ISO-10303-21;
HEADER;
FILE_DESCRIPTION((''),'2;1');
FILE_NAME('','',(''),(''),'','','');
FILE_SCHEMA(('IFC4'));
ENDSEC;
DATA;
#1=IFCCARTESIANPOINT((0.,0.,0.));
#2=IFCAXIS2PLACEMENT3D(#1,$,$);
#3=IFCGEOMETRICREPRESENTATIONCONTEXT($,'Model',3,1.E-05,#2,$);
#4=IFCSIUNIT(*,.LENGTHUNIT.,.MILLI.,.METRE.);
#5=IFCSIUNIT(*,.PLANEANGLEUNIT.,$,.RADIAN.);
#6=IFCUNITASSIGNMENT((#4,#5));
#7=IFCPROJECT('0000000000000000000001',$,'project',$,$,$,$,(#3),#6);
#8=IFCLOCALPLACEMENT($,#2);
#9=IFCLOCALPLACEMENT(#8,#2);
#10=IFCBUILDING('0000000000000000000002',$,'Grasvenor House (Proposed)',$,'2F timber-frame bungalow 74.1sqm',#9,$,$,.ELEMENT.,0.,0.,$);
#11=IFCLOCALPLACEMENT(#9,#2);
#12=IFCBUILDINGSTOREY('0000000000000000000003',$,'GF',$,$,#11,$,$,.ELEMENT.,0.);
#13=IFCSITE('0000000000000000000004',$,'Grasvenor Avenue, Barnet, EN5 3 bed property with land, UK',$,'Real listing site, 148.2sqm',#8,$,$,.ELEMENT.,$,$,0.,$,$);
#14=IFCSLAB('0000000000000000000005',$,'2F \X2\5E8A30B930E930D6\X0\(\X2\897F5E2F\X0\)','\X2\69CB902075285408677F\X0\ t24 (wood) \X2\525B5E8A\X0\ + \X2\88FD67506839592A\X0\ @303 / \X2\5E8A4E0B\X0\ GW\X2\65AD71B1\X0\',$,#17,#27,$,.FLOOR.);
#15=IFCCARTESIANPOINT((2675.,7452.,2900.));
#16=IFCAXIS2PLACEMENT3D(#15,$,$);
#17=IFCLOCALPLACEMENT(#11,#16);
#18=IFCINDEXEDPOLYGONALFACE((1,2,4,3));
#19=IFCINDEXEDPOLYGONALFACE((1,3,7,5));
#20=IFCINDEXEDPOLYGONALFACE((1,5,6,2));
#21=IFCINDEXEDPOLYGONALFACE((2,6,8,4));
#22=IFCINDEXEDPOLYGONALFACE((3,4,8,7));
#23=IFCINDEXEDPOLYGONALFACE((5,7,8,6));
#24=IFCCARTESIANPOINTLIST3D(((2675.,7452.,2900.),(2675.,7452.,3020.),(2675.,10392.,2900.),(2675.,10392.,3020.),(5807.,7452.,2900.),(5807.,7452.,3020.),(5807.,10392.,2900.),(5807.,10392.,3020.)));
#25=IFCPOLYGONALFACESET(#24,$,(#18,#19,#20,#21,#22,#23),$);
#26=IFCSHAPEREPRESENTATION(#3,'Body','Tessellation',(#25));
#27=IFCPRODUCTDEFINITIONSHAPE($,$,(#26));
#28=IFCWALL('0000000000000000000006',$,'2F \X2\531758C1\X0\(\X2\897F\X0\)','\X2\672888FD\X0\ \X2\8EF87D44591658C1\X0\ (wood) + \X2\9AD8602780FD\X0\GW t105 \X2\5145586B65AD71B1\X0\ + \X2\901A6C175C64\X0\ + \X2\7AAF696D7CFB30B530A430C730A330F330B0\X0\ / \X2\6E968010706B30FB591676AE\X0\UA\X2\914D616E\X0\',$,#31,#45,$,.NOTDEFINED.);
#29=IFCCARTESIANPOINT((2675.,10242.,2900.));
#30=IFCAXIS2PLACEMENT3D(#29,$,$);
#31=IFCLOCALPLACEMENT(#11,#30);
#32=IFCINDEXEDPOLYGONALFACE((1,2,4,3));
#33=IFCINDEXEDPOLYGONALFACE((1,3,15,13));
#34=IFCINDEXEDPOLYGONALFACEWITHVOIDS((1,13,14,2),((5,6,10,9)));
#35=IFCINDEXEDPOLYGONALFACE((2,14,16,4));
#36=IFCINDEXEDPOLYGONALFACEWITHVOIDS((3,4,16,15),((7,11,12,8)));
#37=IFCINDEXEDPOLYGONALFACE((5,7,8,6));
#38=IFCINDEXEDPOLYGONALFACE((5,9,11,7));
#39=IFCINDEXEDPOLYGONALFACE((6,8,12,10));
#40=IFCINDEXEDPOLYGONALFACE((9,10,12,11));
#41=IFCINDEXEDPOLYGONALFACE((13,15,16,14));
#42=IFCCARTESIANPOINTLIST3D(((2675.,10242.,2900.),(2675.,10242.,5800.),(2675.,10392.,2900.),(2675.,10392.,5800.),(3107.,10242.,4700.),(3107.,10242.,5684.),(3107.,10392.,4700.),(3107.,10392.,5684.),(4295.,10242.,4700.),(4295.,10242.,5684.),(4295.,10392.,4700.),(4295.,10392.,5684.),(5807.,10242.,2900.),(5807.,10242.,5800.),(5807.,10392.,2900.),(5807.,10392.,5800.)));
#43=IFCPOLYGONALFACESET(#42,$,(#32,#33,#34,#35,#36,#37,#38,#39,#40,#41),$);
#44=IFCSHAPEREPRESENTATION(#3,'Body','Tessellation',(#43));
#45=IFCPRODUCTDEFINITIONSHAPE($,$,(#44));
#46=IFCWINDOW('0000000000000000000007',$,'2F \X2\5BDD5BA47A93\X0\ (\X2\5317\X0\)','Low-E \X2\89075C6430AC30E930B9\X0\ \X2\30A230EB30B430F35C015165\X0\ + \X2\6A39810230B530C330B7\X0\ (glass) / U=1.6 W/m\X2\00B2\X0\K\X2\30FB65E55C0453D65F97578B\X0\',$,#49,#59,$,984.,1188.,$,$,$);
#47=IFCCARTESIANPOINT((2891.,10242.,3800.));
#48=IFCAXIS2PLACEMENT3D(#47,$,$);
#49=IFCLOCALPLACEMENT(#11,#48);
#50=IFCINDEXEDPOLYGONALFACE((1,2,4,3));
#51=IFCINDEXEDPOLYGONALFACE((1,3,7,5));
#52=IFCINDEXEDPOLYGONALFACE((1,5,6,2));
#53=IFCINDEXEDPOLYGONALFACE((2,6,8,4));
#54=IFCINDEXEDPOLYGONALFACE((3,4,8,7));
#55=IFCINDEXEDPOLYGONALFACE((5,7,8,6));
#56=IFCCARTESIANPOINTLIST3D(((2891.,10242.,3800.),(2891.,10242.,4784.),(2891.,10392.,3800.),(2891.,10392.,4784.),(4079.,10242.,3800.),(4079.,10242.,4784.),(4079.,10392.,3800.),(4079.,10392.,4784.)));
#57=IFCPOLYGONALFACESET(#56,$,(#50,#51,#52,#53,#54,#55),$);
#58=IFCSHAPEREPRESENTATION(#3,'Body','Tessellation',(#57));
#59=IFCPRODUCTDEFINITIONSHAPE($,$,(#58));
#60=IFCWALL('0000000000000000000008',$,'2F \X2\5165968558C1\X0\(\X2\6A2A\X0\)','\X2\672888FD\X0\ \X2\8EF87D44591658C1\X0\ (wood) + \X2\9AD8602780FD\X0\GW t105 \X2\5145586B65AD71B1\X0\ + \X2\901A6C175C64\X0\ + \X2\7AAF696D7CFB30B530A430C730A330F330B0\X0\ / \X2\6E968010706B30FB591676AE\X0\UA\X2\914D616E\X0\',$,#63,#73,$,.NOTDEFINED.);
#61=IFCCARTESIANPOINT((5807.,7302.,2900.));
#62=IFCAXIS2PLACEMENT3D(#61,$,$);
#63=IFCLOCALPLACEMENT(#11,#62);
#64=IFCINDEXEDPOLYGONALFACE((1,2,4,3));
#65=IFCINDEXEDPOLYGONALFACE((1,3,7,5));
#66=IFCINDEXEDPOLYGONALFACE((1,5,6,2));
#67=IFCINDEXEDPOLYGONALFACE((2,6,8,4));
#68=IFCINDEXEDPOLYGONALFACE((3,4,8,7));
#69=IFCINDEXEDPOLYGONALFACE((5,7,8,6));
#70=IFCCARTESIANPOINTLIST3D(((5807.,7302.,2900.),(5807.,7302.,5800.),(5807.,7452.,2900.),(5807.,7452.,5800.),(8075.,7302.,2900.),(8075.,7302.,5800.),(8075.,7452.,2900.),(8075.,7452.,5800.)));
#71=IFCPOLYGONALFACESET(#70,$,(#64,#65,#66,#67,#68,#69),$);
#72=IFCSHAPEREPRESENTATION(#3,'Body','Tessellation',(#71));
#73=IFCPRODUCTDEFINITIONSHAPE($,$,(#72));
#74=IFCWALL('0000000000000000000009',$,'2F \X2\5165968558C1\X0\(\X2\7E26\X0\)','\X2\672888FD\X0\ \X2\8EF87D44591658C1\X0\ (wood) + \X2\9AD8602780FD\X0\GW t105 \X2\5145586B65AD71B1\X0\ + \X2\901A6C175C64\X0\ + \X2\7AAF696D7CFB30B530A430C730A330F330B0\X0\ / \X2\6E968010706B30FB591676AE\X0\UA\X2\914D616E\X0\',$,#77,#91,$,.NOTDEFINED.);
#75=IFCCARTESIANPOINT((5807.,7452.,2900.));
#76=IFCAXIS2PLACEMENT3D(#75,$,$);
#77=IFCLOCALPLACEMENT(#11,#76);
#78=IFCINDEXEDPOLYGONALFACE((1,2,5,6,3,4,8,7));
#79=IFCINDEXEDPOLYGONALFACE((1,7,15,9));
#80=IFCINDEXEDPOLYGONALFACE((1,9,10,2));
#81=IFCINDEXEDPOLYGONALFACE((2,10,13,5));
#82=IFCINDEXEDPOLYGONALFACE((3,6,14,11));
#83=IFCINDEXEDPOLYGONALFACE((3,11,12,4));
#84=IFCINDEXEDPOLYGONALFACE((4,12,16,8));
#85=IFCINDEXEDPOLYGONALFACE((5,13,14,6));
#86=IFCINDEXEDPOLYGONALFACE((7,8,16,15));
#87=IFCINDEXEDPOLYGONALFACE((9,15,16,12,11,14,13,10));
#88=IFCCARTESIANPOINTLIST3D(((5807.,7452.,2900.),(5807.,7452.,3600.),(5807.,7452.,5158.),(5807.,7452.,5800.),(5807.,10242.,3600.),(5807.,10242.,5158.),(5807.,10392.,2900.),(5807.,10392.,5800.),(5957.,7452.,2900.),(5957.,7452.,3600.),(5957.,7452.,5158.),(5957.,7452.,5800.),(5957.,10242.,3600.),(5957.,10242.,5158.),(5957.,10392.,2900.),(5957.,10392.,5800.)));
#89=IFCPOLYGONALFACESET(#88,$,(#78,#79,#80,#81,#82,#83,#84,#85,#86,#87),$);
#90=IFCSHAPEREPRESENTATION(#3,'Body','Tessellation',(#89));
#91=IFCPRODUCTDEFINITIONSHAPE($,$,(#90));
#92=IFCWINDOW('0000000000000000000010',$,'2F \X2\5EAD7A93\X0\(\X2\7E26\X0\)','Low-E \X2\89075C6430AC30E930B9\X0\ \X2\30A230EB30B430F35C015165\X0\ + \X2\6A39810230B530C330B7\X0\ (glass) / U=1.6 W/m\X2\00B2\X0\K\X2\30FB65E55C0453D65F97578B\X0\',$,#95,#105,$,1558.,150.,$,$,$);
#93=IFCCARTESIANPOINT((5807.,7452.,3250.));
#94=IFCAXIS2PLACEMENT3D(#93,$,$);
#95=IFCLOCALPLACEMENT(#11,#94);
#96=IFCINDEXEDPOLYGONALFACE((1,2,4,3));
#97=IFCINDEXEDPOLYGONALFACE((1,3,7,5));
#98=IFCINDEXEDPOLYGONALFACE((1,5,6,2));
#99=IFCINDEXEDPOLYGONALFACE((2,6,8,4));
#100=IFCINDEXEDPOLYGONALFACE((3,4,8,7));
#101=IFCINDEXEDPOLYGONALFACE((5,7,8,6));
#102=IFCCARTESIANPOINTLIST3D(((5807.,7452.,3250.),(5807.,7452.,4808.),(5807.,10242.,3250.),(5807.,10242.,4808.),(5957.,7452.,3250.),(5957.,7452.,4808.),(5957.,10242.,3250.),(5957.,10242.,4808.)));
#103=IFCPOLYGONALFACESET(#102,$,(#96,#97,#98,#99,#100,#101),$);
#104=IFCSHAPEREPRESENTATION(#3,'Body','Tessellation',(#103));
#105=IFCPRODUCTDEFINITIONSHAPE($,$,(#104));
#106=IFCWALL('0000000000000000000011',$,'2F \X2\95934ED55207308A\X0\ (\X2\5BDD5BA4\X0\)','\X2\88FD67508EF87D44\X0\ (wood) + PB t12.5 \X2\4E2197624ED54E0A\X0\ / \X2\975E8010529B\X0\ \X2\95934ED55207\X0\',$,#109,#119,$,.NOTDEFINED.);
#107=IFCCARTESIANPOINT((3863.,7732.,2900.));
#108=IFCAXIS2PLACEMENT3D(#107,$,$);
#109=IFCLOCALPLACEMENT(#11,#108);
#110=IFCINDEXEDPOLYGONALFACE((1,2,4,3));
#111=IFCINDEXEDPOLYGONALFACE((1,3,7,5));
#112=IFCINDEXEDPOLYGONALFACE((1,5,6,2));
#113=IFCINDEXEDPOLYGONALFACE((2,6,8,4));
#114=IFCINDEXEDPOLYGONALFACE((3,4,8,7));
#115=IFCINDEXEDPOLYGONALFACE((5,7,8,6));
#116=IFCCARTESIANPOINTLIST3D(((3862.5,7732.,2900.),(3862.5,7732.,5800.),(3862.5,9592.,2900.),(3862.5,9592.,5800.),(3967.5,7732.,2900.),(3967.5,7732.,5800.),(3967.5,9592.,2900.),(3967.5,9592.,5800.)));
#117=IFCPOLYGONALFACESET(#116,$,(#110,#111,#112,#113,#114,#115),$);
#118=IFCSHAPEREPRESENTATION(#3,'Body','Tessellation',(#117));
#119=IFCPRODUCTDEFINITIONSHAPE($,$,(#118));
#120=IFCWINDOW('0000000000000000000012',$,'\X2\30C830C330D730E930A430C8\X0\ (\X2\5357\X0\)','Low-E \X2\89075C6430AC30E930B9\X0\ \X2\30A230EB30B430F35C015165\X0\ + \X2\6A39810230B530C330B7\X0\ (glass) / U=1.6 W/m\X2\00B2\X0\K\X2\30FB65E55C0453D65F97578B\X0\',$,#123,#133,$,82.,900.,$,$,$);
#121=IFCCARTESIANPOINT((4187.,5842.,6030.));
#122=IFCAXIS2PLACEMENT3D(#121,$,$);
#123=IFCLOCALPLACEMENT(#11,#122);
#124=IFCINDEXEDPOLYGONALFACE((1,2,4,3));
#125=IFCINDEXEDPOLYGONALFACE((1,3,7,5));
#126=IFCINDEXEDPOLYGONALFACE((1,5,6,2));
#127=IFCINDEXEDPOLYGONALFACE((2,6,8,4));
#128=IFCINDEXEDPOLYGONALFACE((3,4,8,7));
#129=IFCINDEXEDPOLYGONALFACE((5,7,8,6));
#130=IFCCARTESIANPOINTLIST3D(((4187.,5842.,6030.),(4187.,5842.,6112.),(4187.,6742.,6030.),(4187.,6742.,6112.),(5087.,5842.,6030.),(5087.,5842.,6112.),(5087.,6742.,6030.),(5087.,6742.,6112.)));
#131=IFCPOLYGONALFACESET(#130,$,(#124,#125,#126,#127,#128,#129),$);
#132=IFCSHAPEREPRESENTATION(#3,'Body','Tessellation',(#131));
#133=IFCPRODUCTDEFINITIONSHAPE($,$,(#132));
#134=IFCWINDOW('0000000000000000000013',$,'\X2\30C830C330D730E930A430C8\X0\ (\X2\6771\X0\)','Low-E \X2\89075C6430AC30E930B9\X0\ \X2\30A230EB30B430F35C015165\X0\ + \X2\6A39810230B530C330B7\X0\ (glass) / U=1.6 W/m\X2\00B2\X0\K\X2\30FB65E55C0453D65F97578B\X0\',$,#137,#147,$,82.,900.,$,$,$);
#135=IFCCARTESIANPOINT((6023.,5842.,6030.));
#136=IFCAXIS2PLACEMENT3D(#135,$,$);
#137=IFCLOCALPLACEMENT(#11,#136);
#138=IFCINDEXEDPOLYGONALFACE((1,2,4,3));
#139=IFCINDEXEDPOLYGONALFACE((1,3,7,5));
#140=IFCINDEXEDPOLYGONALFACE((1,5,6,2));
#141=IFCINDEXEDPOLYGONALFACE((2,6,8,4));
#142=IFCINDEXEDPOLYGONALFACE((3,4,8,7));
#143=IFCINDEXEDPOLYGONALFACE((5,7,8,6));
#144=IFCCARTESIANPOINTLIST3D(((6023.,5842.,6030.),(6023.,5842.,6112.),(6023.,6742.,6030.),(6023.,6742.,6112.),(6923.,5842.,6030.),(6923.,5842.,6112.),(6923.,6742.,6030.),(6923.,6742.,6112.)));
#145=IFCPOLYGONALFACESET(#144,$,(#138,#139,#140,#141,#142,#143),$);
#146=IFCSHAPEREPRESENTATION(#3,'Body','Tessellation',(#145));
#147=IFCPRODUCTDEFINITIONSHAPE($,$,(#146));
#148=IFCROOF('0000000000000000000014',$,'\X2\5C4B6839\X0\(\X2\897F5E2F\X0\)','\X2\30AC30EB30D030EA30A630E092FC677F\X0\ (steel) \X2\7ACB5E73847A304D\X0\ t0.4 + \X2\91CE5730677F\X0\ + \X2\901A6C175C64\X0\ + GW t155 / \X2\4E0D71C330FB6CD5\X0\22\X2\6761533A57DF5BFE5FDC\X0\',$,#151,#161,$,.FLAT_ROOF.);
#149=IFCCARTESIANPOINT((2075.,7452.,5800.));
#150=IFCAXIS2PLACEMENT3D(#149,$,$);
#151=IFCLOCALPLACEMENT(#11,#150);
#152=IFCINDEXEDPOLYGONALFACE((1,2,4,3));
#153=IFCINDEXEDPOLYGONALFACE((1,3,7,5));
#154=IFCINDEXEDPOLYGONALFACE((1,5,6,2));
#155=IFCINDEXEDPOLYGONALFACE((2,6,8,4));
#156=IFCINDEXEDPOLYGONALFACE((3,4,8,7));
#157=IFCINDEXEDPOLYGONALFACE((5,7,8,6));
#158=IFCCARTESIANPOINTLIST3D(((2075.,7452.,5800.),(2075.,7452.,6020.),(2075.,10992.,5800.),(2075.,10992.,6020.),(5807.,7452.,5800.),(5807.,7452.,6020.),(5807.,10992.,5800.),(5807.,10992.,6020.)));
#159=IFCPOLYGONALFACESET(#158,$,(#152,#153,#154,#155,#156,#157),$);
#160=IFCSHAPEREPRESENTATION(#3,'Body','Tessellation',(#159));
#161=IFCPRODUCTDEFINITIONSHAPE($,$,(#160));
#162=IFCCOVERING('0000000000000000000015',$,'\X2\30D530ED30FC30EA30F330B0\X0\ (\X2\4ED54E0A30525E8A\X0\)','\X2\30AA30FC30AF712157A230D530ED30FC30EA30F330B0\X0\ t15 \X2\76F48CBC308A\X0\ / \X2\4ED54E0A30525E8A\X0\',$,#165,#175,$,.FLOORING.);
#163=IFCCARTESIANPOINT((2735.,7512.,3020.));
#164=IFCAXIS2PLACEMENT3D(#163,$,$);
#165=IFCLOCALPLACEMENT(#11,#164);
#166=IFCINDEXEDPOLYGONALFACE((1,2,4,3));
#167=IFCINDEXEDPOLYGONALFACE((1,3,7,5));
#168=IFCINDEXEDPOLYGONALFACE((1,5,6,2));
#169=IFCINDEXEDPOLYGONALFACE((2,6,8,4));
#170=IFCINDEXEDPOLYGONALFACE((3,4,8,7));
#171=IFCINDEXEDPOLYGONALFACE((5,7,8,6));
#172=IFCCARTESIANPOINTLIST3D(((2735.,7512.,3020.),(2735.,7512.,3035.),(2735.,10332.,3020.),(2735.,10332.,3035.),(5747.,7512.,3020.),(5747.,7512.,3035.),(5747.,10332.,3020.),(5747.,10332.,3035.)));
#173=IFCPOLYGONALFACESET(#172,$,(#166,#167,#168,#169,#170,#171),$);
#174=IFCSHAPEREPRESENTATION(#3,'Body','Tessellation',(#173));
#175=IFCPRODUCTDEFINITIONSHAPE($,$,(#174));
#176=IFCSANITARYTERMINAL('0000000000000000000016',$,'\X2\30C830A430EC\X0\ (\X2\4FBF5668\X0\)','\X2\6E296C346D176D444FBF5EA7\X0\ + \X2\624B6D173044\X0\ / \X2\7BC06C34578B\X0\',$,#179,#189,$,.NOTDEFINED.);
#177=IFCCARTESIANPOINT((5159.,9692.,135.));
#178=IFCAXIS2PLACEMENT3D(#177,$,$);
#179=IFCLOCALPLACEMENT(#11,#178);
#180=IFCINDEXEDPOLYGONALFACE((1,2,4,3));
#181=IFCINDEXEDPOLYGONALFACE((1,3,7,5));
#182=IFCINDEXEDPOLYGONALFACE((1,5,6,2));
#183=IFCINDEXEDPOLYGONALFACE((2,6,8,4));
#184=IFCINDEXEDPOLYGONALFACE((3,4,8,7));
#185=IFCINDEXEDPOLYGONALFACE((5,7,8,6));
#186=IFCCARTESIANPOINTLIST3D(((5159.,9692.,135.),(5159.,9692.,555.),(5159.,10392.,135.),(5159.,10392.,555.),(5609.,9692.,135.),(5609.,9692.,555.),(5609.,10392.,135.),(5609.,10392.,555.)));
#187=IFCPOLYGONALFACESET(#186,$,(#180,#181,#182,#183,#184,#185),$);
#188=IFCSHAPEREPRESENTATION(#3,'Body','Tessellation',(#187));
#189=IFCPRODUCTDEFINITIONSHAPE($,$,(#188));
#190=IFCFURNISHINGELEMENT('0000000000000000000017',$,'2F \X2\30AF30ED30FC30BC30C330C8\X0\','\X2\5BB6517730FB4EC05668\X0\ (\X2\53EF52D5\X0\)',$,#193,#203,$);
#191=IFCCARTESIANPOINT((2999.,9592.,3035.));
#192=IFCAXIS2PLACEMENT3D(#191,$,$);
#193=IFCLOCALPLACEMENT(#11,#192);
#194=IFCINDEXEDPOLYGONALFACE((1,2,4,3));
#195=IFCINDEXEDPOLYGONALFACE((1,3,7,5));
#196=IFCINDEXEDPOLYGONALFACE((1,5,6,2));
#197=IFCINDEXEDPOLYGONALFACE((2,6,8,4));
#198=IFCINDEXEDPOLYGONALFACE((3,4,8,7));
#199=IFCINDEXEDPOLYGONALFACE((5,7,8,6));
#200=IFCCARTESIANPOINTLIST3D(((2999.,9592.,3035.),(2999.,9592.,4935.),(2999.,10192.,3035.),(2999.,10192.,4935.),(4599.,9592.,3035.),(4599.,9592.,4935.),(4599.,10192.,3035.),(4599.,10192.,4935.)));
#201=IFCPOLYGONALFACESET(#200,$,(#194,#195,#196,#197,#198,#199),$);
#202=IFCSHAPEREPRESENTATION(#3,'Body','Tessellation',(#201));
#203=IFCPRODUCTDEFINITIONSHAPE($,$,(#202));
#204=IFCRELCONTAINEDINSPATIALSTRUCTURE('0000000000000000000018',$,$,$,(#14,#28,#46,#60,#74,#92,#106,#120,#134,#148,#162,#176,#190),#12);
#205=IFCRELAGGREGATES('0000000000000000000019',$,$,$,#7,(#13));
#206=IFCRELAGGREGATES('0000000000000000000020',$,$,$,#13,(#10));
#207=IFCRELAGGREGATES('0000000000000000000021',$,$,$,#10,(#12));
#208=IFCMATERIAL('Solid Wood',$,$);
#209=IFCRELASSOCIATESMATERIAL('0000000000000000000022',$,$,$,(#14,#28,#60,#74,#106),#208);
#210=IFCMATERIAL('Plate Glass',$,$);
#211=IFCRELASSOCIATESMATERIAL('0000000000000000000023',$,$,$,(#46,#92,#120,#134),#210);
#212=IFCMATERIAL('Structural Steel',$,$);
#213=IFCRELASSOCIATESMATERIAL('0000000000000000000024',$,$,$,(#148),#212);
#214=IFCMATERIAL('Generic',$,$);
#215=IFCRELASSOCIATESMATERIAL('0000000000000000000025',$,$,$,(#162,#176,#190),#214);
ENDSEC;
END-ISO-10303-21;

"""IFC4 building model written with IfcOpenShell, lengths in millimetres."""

from ifc_helpers import new_model, si_unit, frame, frame_2d, origin, place, context, project, spatial, rectangle, extrude, material, element, fill, save


model = new_model("IFC4")

# Units and contexts
model_context = context("Model", 3, precision=1e-05, world=origin())
ifc_project = project(units=[si_unit("LENGTHUNIT", "METRE", prefix="MILLI"), si_unit("PLANEANGLEUNIT", "RADIAN")], contexts=[model_context])

# Site, building, storey
site_placement = place(None, origin())
site = spatial("IfcSite", under=ifc_project, at=site_placement, Name="Grasvenor Avenue, Barnet, EN5 3 bed property with land, UK", ObjectType="Real listing site, 148.2sqm", CompositionType="ELEMENT", RefElevation=0.0)
building_placement = place(site_placement, origin())
building = spatial("IfcBuilding", under=site, at=building_placement, Name="Grasvenor House (Proposed)", ObjectType="2F timber-frame bungalow 74.1sqm", CompositionType="ELEMENT", ElevationOfRefHeight=0.0, ElevationOfTerrain=0.0)
storey_placement = place(building_placement, origin())
storey = spatial("IfcBuildingStorey", under=building, at=storey_placement, Name="GF", CompositionType="ELEMENT", Elevation=0.0)

# Slab
ifc_material_1 = material(Name="Solid Wood")
slab_placement = place(storey_placement, frame((2675.0, 7452.0, 2900.0)))
element("IfcSlab", 1, at=slab_placement, inside=storey, material=ifc_material_1, Name="2F 床スラブ(西帯)", Description="構造用合板 t24 (wood) 剛床 + 製材根太 @303 / 床下 GW断熱", PredefinedType="FLOOR", context=model_context, shape_type="SweptSolid", body=[
    extrude(rectangle(XDim=3132.0, YDim=2940.0, at=frame_2d((1566.0, 1470.0))), frame((2675.0, 7452.0, 2900.0)), (0.0, 0.0, 1.0), 120.0),
])

# Wall, opening, window
wall_1_placement = place(storey_placement, frame((2675.0, 10242.0, 2900.0)))
wall_1 = element("IfcWall", 2, at=wall_1_placement, inside=storey, material=ifc_material_1, Name="2F 北壁(西)", Description="木製 軸組外壁 (wood) + 高性能GW t105 充填断熱 + 通気層 + 窯業系サイディング / 準耐火・外皮UA配慮", PredefinedType="NOTDEFINED", context=model_context, shape_type="SweptSolid", body=[
    extrude(rectangle(XDim=3132.0, YDim=150.0, at=frame_2d((1566.0, 75.0))), frame((2675.0, 10242.0, 2900.0)), (0.0, 0.0, 1.0), 2900.0),
])
opening_1_placement = place(storey_placement, frame((2891.0, 10242.0, 3800.0)))
opening_1 = element("IfcOpeningElement", 3, at=opening_1_placement, cuts=wall_1, PredefinedType="NOTDEFINED", context=model_context, shape_type="SweptSolid", body=[
    extrude(rectangle(XDim=1188.0, YDim=150.0, at=frame_2d((594.0, 75.0))), frame((2891.0, 10242.0, 3800.0)), (0.0, 0.0, 1.0), 984.0),
])
ifc_material_2 = material(Name="Plate Glass")
window_1_placement = place(storey_placement, frame((2891.0, 10242.0, 3800.0)))
window_1 = element("IfcWindow", 4, at=window_1_placement, inside=storey, material=ifc_material_2, Name="2F 寝室窓 (北)", Description="Low-E 複層ガラス アルゴン封入 + 樹脂サッシ (glass) / U=1.6 W/m²K・日射取得型", OverallHeight=984.0, OverallWidth=1188.0, context=model_context, shape_type="SweptSolid", body=[
    extrude(rectangle(XDim=1188.0, YDim=150.0, at=frame_2d((594.0, 75.0))), frame((2891.0, 10242.0, 3800.0)), (0.0, 0.0, 1.0), 984.0),
])
fill(opening_1, window_1)

# Wall
wall_2_placement = place(storey_placement, frame((5807.0, 7302.0, 2900.0)))
element("IfcWall", 5, at=wall_2_placement, inside=storey, material=ifc_material_1, Name="2F 入隅壁(横)", Description="木製 軸組外壁 (wood) + 高性能GW t105 充填断熱 + 通気層 + 窯業系サイディング / 準耐火・外皮UA配慮", PredefinedType="NOTDEFINED", context=model_context, shape_type="SweptSolid", body=[
    extrude(rectangle(XDim=2268.0, YDim=150.0, at=frame_2d((1134.0, 75.0))), frame((5807.0, 7302.0, 2900.0)), (0.0, 0.0, 1.0), 2900.0),
])

# Wall, opening, window
wall_3_placement = place(storey_placement, frame((5807.0, 7452.0, 2900.0)))
wall_3 = element("IfcWall", 6, at=wall_3_placement, inside=storey, material=ifc_material_1, Name="2F 入隅壁(縦)", Description="木製 軸組外壁 (wood) + 高性能GW t105 充填断熱 + 通気層 + 窯業系サイディング / 準耐火・外皮UA配慮", PredefinedType="NOTDEFINED", context=model_context, shape_type="SweptSolid", body=[
    extrude(rectangle(XDim=150.0, YDim=2940.0, at=frame_2d((75.0, 1470.0))), frame((5807.0, 7452.0, 2900.0)), (0.0, 0.0, 1.0), 2900.0),
])
opening_2_placement = place(storey_placement, frame((5807.0, 7452.0, 3250.0)))
opening_2 = element("IfcOpeningElement", 7, at=opening_2_placement, cuts=wall_3, PredefinedType="NOTDEFINED", context=model_context, shape_type="SweptSolid", body=[
    extrude(rectangle(XDim=150.0, YDim=2790.0, at=frame_2d((75.0, 1395.0))), frame((5807.0, 7452.0, 3250.0)), (0.0, 0.0, 1.0), 1558.0),
])
window_2_placement = place(storey_placement, frame((5807.0, 7452.0, 3250.0)))
window_2 = element("IfcWindow", 8, at=window_2_placement, inside=storey, material=ifc_material_2, Name="2F 庭窓(縦)", Description="Low-E 複層ガラス アルゴン封入 + 樹脂サッシ (glass) / U=1.6 W/m²K・日射取得型", OverallHeight=1558.0, OverallWidth=150.0, context=model_context, shape_type="SweptSolid", body=[
    extrude(rectangle(XDim=150.0, YDim=2790.0, at=frame_2d((75.0, 1395.0))), frame((5807.0, 7452.0, 3250.0)), (0.0, 0.0, 1.0), 1558.0),
])
fill(opening_2, window_2)

# Wall
wall_4_placement = place(storey_placement, frame((3863.0, 7732.0, 2900.0)))
element("IfcWall", 9, at=wall_4_placement, inside=storey, material=ifc_material_1, Name="2F 間仕切り (寝室)", Description="製材軸組 (wood) + PB t12.5 両面仕上 / 非耐力 間仕切", PredefinedType="NOTDEFINED", context=model_context, shape_type="SweptSolid", body=[
    extrude(rectangle(XDim=105.0, YDim=1860.0, at=frame_2d((52.0, 930.0))), frame((3863.0, 7732.0, 2900.0)), (0.0, 0.0, 1.0), 2900.0),
])

# Windows
window_3_placement = place(storey_placement, frame((4187.0, 5842.0, 6030.0)))
element("IfcWindow", 10, at=window_3_placement, inside=storey, material=ifc_material_2, Name="トップライト (南)", Description="Low-E 複層ガラス アルゴン封入 + 樹脂サッシ (glass) / U=1.6 W/m²K・日射取得型", OverallHeight=82.0, OverallWidth=900.0, context=model_context, shape_type="SweptSolid", body=[
    extrude(rectangle(XDim=900.0, YDim=900.0, at=frame_2d((450.0, 450.0))), frame((4187.0, 5842.0, 6030.0)), (0.0, 0.0, 1.0), 82.0),
])
window_4_placement = place(storey_placement, frame((6023.0, 5842.0, 6030.0)))
element("IfcWindow", 11, at=window_4_placement, inside=storey, material=ifc_material_2, Name="トップライト (東)", Description="Low-E 複層ガラス アルゴン封入 + 樹脂サッシ (glass) / U=1.6 W/m²K・日射取得型", OverallHeight=82.0, OverallWidth=900.0, context=model_context, shape_type="SweptSolid", body=[
    extrude(rectangle(XDim=900.0, YDim=900.0, at=frame_2d((450.0, 450.0))), frame((6023.0, 5842.0, 6030.0)), (0.0, 0.0, 1.0), 82.0),
])

# Roof
ifc_material_3 = material(Name="Structural Steel")
for number, where, name in (
    (12, (2075.0, 7452.0, 5800.0), "屋根(西帯)"),
):
    element("IfcRoof", number, at=place(storey_placement, frame(where)), inside=storey, material=ifc_material_3, Name=name, Description="ガルバリウム鋼板 (steel) 立平葺き t0.4 + 野地板 + 通気層 + GW t155 / 不燃・法22条区域対応", PredefinedType="FLAT_ROOF", context=model_context, shape_type="SweptSolid", body=[
        extrude(rectangle(XDim=3732.0, YDim=3540.0, at=frame_2d((1866.0, 1770.0))), frame((2075.0, 7452.0, 5800.0)), (0.0, 0.0, 1.0), 220.0),
    ])

# Covering
ifc_material_4 = material(Name="Generic")
covering_placement = place(storey_placement, frame((2735.0, 7512.0, 3020.0)))
element("IfcCovering", 13, at=covering_placement, inside=storey, material=ifc_material_4, Name="フローリング (仕上げ床)", Description="オーク無垢フローリング t15 直貼り / 仕上げ床", PredefinedType="FLOORING", context=model_context, shape_type="SweptSolid", body=[
    extrude(rectangle(XDim=3012.0, YDim=2820.0, at=frame_2d((1506.0, 1410.0))), frame((2735.0, 7512.0, 3020.0)), (0.0, 0.0, 1.0), 15.0),
])

# Sanitary terminal
sanitary_terminal_placement = place(storey_placement, frame((5159.0, 9692.0, 135.0)))
element("IfcSanitaryTerminal", 14, at=sanitary_terminal_placement, inside=storey, material=ifc_material_4, Name="トイレ (便器)", Description="温水洗浄便座 + 手洗い / 節水型", PredefinedType="NOTDEFINED", context=model_context, shape_type="SweptSolid", body=[
    extrude(rectangle(XDim=450.0, YDim=700.0, at=frame_2d((225.0, 350.0))), frame((5159.0, 9692.0, 135.0)), (0.0, 0.0, 1.0), 420.0),
])

# Furnishing element
furnishing_1_placement = place(storey_placement, frame((2999.0, 9592.0, 3035.0)))
element("IfcFurnishingElement", 15, at=furnishing_1_placement, inside=storey, material=ifc_material_4, Name="2F クローゼット", Description="家具・什器 (可動)", context=model_context, shape_type="SweptSolid", body=[
    extrude(rectangle(XDim=1600.0, YDim=600.0, at=frame_2d((800.0, 300.0))), frame((2999.0, 9592.0, 3035.0)), (0.0, 0.0, 1.0), 1900.0),
])

save(model, "model.ifc")
